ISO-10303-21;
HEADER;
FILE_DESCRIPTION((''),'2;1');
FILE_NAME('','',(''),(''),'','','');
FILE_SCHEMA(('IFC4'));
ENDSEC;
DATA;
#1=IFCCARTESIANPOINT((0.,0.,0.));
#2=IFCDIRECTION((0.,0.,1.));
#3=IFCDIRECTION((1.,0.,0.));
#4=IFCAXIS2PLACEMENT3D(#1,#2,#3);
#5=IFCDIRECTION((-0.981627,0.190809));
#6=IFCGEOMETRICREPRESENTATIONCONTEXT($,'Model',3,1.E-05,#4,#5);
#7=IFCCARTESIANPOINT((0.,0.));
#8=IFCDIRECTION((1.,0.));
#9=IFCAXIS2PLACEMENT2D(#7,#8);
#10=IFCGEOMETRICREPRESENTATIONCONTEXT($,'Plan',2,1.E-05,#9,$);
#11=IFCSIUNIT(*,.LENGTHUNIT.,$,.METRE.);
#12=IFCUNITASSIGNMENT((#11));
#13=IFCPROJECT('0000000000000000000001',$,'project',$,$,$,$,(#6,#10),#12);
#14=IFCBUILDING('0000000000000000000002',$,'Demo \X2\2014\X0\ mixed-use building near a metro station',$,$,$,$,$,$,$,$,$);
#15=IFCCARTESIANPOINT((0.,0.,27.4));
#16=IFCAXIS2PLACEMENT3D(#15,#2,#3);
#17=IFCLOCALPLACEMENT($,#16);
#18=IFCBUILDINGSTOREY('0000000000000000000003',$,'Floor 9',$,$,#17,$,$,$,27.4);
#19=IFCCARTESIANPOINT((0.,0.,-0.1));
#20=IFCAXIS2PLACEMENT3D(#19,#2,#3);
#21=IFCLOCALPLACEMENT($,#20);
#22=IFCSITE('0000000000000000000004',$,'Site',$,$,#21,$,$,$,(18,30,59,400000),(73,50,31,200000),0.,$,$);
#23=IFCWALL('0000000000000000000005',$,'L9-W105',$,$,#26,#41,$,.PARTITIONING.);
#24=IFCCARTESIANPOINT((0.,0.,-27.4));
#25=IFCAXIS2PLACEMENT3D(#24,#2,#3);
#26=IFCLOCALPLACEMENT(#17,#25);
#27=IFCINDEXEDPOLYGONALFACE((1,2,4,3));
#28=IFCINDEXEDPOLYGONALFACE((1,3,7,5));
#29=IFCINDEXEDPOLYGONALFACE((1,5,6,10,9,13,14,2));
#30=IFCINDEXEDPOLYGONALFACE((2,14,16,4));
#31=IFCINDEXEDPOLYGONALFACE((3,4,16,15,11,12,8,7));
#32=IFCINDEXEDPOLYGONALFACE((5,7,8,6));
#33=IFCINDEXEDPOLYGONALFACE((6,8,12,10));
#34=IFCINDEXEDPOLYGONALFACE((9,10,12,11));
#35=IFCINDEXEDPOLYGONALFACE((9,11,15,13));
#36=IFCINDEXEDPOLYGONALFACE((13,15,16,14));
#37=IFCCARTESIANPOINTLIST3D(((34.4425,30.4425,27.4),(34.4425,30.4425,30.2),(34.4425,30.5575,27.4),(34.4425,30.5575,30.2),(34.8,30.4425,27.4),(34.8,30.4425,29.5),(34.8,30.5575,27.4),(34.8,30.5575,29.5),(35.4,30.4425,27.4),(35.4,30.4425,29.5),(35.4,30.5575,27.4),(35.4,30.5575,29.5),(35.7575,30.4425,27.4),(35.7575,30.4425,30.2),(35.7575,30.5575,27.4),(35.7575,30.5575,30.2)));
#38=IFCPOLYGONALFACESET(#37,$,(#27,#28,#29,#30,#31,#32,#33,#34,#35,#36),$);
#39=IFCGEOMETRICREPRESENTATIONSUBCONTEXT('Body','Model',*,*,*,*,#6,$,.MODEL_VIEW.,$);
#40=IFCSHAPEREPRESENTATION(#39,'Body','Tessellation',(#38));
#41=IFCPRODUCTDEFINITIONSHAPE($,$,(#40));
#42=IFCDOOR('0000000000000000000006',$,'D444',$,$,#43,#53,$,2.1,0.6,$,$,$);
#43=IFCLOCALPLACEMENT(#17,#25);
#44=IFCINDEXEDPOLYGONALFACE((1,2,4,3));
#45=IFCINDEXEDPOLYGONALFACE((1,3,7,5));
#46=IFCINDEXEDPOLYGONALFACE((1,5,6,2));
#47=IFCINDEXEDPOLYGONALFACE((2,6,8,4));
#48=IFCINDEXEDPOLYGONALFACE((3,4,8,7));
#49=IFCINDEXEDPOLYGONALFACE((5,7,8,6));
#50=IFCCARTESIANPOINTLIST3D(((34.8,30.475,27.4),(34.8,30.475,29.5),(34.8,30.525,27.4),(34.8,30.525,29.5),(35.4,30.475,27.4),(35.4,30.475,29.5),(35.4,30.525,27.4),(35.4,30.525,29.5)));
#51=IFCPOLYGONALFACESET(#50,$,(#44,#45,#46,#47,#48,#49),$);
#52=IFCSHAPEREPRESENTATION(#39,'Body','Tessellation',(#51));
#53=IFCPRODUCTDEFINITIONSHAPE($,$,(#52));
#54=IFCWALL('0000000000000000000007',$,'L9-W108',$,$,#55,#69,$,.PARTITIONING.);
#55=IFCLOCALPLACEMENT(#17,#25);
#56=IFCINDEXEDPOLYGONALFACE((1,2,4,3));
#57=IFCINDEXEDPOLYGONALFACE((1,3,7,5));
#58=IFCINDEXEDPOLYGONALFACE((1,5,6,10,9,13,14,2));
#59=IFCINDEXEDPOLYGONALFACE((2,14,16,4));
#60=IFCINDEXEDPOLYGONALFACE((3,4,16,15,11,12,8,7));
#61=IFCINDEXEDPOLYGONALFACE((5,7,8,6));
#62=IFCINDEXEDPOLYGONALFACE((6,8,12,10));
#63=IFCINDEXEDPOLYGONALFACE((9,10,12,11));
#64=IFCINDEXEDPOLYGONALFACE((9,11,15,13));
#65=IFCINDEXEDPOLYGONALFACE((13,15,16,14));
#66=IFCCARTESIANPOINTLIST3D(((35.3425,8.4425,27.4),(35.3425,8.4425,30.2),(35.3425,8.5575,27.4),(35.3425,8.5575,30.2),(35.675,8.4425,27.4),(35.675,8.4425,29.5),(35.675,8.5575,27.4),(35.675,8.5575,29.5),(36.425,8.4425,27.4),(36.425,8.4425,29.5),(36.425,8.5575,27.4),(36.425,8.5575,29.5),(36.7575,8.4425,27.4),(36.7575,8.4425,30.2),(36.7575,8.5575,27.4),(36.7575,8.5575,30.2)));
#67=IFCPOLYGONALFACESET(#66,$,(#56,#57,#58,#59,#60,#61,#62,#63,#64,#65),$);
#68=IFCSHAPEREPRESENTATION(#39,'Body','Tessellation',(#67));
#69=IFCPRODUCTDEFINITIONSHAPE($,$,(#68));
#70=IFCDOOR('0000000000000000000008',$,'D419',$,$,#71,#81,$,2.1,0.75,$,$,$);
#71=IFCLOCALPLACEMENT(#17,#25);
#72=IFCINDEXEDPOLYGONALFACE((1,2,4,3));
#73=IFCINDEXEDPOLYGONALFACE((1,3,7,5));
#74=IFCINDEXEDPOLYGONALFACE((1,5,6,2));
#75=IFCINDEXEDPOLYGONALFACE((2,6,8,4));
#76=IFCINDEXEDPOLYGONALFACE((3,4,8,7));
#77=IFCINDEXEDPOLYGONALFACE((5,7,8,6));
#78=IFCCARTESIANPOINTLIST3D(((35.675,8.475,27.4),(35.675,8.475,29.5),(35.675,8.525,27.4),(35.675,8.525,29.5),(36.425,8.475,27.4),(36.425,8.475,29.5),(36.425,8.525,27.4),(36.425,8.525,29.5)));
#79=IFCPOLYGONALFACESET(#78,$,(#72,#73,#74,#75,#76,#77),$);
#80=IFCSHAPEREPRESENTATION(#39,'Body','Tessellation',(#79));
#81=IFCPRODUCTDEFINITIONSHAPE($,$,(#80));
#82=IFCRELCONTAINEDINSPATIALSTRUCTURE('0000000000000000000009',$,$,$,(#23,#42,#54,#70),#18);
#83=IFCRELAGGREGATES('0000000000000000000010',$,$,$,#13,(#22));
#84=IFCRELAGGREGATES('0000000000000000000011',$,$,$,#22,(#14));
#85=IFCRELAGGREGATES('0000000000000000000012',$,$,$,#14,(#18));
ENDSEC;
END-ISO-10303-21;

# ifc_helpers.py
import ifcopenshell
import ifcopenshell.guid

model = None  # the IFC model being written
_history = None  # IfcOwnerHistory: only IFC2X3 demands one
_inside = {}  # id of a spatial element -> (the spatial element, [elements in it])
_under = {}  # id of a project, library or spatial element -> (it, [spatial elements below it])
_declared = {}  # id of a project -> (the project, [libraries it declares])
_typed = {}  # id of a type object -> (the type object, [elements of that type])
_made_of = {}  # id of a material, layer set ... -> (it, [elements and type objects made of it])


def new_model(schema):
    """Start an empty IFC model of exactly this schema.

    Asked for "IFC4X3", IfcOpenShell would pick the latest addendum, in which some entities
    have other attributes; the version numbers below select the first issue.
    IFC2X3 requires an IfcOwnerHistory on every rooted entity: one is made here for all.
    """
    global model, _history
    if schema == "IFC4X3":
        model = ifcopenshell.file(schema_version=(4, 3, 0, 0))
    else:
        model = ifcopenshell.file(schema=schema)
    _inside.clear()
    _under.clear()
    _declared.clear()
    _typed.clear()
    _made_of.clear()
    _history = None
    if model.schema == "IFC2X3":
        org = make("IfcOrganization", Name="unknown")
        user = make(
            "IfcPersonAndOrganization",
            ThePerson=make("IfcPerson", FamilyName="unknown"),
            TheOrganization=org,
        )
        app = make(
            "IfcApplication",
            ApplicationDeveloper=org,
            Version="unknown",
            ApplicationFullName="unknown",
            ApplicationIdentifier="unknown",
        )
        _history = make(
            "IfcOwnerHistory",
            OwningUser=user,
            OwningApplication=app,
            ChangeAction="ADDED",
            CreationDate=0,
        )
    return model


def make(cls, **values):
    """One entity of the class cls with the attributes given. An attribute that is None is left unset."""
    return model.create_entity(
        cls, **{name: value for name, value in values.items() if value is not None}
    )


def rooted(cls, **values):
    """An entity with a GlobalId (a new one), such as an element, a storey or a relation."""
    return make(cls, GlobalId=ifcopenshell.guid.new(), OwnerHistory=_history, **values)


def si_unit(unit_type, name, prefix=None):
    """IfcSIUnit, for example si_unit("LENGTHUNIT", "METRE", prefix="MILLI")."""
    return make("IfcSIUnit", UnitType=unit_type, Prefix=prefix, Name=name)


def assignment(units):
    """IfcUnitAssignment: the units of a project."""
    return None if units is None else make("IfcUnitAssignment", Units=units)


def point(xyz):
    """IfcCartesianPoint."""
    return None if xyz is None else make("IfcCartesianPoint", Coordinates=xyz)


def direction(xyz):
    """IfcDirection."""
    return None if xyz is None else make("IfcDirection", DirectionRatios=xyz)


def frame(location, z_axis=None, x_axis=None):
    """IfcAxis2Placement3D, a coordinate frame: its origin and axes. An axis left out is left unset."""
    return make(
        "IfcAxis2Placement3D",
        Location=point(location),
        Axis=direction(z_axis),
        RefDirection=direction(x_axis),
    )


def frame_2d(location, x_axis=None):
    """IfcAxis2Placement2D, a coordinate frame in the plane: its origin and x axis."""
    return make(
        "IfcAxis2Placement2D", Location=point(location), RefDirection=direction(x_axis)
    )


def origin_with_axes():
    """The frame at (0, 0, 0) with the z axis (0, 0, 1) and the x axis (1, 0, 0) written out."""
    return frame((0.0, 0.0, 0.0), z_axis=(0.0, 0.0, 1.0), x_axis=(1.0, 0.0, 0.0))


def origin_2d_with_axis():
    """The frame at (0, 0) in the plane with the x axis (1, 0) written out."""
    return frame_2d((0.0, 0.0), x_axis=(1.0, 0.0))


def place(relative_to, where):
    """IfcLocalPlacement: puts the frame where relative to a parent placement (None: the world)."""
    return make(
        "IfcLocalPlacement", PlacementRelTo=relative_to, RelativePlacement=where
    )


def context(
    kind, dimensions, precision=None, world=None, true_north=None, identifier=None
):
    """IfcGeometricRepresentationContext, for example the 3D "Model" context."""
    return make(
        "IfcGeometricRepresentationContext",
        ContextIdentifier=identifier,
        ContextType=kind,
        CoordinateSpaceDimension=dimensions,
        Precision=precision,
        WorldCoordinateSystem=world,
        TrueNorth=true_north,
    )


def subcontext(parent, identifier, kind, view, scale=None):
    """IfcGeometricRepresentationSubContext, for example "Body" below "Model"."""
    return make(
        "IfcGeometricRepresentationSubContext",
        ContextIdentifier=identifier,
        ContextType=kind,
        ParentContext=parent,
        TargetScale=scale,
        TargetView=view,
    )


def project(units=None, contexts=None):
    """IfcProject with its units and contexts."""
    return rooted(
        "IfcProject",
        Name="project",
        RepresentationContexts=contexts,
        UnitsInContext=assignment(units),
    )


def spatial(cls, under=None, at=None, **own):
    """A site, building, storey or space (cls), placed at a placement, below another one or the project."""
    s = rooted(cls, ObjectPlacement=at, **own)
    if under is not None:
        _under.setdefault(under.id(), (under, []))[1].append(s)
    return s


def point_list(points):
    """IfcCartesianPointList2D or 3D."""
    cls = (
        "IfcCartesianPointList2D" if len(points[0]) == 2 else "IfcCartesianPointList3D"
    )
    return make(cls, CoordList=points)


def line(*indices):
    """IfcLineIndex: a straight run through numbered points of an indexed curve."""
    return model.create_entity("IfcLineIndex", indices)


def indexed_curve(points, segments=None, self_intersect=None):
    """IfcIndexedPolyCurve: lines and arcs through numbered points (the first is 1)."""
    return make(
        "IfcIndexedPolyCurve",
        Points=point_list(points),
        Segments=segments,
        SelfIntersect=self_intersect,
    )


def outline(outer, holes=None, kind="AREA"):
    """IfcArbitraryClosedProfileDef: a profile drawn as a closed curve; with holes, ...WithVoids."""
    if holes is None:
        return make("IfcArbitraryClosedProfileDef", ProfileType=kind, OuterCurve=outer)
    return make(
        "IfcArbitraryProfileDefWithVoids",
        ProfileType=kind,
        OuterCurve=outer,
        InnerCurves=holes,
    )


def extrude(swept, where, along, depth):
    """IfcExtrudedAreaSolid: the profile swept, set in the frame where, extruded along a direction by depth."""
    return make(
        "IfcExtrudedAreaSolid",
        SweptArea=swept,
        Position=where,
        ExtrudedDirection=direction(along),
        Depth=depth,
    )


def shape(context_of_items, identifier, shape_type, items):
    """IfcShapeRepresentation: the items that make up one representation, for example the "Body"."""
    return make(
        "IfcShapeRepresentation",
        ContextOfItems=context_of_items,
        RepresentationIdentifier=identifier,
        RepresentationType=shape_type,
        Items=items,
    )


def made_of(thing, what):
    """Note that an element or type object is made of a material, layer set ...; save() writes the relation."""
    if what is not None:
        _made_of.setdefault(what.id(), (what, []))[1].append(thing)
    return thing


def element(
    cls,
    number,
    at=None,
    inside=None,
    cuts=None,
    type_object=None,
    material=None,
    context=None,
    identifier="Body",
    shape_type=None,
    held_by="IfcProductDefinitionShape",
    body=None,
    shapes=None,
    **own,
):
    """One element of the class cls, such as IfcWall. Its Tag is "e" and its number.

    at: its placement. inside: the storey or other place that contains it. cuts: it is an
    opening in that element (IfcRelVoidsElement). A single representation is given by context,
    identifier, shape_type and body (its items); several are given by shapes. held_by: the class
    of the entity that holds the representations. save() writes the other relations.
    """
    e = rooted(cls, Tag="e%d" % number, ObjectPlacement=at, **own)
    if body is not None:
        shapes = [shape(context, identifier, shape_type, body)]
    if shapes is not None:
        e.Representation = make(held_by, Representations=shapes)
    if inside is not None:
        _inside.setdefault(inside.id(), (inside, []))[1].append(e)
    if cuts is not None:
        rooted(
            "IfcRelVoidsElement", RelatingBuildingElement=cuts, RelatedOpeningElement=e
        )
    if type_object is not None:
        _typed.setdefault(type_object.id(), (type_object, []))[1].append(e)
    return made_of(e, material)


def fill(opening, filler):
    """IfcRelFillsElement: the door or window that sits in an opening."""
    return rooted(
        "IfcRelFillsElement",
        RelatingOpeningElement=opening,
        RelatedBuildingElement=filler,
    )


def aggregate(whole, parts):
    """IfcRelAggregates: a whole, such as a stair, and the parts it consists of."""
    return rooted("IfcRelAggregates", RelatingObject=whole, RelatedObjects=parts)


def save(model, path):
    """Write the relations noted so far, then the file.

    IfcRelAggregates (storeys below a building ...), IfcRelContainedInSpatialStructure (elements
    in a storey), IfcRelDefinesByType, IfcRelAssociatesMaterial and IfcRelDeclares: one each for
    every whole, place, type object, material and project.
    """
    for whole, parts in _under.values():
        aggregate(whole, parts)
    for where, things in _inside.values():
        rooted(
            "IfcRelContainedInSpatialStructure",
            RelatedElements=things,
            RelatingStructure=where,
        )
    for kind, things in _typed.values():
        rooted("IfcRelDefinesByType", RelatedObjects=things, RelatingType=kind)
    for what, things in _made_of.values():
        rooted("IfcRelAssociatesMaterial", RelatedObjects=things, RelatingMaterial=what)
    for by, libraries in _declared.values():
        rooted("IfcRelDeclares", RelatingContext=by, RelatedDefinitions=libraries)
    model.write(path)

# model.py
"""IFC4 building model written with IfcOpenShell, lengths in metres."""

from ifc_helpers import new_model, si_unit, direction, frame, origin_with_axes, origin_2d_with_axis, place, context, subcontext, project, spatial, line, indexed_curve, outline, extrude, element, fill, save


model = new_model("IFC4")

# Units and contexts
model_context = context("Model", 3, precision=1e-05, world=origin_with_axes(), true_north=direction((-0.981627, 0.190809)))
plan_context = context("Plan", 2, precision=1e-05, world=origin_2d_with_axis())
body_context = subcontext(model_context, "Body", "Model", "MODEL_VIEW")
ifc_project = project(units=[si_unit("LENGTHUNIT", "METRE")], contexts=[model_context, plan_context])

# Site, building, storey
site_placement = place(None, frame((0.0, 0.0, -0.1), z_axis=(0.0, 0.0, 1.0), x_axis=(1.0, 0.0, 0.0)))
site = spatial("IfcSite", under=ifc_project, at=site_placement, Name="Site", RefLatitude=(18, 30, 59, 400000), RefLongitude=(73, 50, 31, 200000), RefElevation=0.0)
building = spatial("IfcBuilding", under=site, Name="Demo — mixed-use building near a metro station")
storey_placement = place(None, frame((0.0, 0.0, 27.4), z_axis=(0.0, 0.0, 1.0), x_axis=(1.0, 0.0, 0.0)))
storey = spatial("IfcBuildingStorey", under=building, at=storey_placement, Name="Floor 9", Elevation=27.4)

# Wall, opening, door
wall_1_placement = place(storey_placement, frame((0.0, 0.0, -27.4), z_axis=(0.0, 0.0, 1.0), x_axis=(1.0, 0.0, 0.0)))
wall_1 = element("IfcWall", 1, at=wall_1_placement, inside=storey, Name="L9-W105", PredefinedType="PARTITIONING", context=body_context, shape_type="SweptSolid", body=[
    extrude(outline(indexed_curve([(35.7575, 30.4425), (34.4425, 30.4425), (34.4425, 30.5575), (35.7575, 30.5575)], segments=[line(1, 2, 3, 4, 1)])), frame((0.0, 0.0, 27.4), z_axis=(0.0, 0.0, 1.0), x_axis=(1.0, 0.0, 0.0)), (0.0, 0.0, 1.0), 2.8),
])
opening_1_placement = place(wall_1_placement, origin_with_axes())
opening_1 = element("IfcOpeningElement", 2, at=opening_1_placement, cuts=wall_1, context=body_context, shape_type="SweptSolid", body=[
    extrude(outline(indexed_curve([(35.4, 30.3925), (34.8, 30.3925), (34.8, 30.6075), (35.4, 30.6075)], segments=[line(1, 2, 3, 4, 1)])), frame((0.0, 0.0, 27.4), z_axis=(0.0, 0.0, 1.0), x_axis=(1.0, 0.0, 0.0)), (0.0, 0.0, 1.0), 2.1),
])
door_1_placement = place(storey_placement, frame((0.0, 0.0, -27.4), z_axis=(0.0, 0.0, 1.0), x_axis=(1.0, 0.0, 0.0)))
door_1 = element("IfcDoor", 3, at=door_1_placement, inside=storey, Name="D444", OverallHeight=2.1, OverallWidth=0.6, context=body_context, shape_type="SweptSolid", body=[
    extrude(outline(indexed_curve([(35.4, 30.475), (34.8, 30.475), (34.8, 30.525), (35.4, 30.525)], segments=[line(1, 2, 3, 4, 1)])), frame((0.0, 0.0, 27.4), z_axis=(0.0, 0.0, 1.0), x_axis=(1.0, 0.0, 0.0)), (0.0, 0.0, 1.0), 2.1),
])
fill(opening_1, door_1)

# Wall, opening, door
wall_2_placement = place(storey_placement, frame((0.0, 0.0, -27.4), z_axis=(0.0, 0.0, 1.0), x_axis=(1.0, 0.0, 0.0)))
wall_2 = element("IfcWall", 4, at=wall_2_placement, inside=storey, Name="L9-W108", PredefinedType="PARTITIONING", context=body_context, shape_type="SweptSolid", body=[
    extrude(outline(indexed_curve([(36.7575, 8.4425), (35.3425, 8.4425), (35.3425, 8.5575), (36.7575, 8.5575)], segments=[line(1, 2, 3, 4, 1)])), frame((0.0, 0.0, 27.4), z_axis=(0.0, 0.0, 1.0), x_axis=(1.0, 0.0, 0.0)), (0.0, 0.0, 1.0), 2.8),
])
opening_2_placement = place(wall_2_placement, origin_with_axes())
opening_2 = element("IfcOpeningElement", 5, at=opening_2_placement, cuts=wall_2, context=body_context, shape_type="SweptSolid", body=[
    extrude(outline(indexed_curve([(36.425, 8.3925), (35.675, 8.3925), (35.675, 8.6075), (36.425, 8.6075)], segments=[line(1, 2, 3, 4, 1)])), frame((0.0, 0.0, 27.4), z_axis=(0.0, 0.0, 1.0), x_axis=(1.0, 0.0, 0.0)), (0.0, 0.0, 1.0), 2.1),
])
door_2_placement = place(storey_placement, frame((0.0, 0.0, -27.4), z_axis=(0.0, 0.0, 1.0), x_axis=(1.0, 0.0, 0.0)))
door_2 = element("IfcDoor", 6, at=door_2_placement, inside=storey, Name="D419", OverallHeight=2.1, OverallWidth=0.75, context=body_context, shape_type="SweptSolid", body=[
    extrude(outline(indexed_curve([(36.425, 8.475), (35.675, 8.475), (35.675, 8.525), (36.425, 8.525)], segments=[line(1, 2, 3, 4, 1)])), frame((0.0, 0.0, 27.4), z_axis=(0.0, 0.0, 1.0), x_axis=(1.0, 0.0, 0.0)), (0.0, 0.0, 1.0), 2.1),
])
fill(opening_2, door_2)

save(model, "model.ifc")
